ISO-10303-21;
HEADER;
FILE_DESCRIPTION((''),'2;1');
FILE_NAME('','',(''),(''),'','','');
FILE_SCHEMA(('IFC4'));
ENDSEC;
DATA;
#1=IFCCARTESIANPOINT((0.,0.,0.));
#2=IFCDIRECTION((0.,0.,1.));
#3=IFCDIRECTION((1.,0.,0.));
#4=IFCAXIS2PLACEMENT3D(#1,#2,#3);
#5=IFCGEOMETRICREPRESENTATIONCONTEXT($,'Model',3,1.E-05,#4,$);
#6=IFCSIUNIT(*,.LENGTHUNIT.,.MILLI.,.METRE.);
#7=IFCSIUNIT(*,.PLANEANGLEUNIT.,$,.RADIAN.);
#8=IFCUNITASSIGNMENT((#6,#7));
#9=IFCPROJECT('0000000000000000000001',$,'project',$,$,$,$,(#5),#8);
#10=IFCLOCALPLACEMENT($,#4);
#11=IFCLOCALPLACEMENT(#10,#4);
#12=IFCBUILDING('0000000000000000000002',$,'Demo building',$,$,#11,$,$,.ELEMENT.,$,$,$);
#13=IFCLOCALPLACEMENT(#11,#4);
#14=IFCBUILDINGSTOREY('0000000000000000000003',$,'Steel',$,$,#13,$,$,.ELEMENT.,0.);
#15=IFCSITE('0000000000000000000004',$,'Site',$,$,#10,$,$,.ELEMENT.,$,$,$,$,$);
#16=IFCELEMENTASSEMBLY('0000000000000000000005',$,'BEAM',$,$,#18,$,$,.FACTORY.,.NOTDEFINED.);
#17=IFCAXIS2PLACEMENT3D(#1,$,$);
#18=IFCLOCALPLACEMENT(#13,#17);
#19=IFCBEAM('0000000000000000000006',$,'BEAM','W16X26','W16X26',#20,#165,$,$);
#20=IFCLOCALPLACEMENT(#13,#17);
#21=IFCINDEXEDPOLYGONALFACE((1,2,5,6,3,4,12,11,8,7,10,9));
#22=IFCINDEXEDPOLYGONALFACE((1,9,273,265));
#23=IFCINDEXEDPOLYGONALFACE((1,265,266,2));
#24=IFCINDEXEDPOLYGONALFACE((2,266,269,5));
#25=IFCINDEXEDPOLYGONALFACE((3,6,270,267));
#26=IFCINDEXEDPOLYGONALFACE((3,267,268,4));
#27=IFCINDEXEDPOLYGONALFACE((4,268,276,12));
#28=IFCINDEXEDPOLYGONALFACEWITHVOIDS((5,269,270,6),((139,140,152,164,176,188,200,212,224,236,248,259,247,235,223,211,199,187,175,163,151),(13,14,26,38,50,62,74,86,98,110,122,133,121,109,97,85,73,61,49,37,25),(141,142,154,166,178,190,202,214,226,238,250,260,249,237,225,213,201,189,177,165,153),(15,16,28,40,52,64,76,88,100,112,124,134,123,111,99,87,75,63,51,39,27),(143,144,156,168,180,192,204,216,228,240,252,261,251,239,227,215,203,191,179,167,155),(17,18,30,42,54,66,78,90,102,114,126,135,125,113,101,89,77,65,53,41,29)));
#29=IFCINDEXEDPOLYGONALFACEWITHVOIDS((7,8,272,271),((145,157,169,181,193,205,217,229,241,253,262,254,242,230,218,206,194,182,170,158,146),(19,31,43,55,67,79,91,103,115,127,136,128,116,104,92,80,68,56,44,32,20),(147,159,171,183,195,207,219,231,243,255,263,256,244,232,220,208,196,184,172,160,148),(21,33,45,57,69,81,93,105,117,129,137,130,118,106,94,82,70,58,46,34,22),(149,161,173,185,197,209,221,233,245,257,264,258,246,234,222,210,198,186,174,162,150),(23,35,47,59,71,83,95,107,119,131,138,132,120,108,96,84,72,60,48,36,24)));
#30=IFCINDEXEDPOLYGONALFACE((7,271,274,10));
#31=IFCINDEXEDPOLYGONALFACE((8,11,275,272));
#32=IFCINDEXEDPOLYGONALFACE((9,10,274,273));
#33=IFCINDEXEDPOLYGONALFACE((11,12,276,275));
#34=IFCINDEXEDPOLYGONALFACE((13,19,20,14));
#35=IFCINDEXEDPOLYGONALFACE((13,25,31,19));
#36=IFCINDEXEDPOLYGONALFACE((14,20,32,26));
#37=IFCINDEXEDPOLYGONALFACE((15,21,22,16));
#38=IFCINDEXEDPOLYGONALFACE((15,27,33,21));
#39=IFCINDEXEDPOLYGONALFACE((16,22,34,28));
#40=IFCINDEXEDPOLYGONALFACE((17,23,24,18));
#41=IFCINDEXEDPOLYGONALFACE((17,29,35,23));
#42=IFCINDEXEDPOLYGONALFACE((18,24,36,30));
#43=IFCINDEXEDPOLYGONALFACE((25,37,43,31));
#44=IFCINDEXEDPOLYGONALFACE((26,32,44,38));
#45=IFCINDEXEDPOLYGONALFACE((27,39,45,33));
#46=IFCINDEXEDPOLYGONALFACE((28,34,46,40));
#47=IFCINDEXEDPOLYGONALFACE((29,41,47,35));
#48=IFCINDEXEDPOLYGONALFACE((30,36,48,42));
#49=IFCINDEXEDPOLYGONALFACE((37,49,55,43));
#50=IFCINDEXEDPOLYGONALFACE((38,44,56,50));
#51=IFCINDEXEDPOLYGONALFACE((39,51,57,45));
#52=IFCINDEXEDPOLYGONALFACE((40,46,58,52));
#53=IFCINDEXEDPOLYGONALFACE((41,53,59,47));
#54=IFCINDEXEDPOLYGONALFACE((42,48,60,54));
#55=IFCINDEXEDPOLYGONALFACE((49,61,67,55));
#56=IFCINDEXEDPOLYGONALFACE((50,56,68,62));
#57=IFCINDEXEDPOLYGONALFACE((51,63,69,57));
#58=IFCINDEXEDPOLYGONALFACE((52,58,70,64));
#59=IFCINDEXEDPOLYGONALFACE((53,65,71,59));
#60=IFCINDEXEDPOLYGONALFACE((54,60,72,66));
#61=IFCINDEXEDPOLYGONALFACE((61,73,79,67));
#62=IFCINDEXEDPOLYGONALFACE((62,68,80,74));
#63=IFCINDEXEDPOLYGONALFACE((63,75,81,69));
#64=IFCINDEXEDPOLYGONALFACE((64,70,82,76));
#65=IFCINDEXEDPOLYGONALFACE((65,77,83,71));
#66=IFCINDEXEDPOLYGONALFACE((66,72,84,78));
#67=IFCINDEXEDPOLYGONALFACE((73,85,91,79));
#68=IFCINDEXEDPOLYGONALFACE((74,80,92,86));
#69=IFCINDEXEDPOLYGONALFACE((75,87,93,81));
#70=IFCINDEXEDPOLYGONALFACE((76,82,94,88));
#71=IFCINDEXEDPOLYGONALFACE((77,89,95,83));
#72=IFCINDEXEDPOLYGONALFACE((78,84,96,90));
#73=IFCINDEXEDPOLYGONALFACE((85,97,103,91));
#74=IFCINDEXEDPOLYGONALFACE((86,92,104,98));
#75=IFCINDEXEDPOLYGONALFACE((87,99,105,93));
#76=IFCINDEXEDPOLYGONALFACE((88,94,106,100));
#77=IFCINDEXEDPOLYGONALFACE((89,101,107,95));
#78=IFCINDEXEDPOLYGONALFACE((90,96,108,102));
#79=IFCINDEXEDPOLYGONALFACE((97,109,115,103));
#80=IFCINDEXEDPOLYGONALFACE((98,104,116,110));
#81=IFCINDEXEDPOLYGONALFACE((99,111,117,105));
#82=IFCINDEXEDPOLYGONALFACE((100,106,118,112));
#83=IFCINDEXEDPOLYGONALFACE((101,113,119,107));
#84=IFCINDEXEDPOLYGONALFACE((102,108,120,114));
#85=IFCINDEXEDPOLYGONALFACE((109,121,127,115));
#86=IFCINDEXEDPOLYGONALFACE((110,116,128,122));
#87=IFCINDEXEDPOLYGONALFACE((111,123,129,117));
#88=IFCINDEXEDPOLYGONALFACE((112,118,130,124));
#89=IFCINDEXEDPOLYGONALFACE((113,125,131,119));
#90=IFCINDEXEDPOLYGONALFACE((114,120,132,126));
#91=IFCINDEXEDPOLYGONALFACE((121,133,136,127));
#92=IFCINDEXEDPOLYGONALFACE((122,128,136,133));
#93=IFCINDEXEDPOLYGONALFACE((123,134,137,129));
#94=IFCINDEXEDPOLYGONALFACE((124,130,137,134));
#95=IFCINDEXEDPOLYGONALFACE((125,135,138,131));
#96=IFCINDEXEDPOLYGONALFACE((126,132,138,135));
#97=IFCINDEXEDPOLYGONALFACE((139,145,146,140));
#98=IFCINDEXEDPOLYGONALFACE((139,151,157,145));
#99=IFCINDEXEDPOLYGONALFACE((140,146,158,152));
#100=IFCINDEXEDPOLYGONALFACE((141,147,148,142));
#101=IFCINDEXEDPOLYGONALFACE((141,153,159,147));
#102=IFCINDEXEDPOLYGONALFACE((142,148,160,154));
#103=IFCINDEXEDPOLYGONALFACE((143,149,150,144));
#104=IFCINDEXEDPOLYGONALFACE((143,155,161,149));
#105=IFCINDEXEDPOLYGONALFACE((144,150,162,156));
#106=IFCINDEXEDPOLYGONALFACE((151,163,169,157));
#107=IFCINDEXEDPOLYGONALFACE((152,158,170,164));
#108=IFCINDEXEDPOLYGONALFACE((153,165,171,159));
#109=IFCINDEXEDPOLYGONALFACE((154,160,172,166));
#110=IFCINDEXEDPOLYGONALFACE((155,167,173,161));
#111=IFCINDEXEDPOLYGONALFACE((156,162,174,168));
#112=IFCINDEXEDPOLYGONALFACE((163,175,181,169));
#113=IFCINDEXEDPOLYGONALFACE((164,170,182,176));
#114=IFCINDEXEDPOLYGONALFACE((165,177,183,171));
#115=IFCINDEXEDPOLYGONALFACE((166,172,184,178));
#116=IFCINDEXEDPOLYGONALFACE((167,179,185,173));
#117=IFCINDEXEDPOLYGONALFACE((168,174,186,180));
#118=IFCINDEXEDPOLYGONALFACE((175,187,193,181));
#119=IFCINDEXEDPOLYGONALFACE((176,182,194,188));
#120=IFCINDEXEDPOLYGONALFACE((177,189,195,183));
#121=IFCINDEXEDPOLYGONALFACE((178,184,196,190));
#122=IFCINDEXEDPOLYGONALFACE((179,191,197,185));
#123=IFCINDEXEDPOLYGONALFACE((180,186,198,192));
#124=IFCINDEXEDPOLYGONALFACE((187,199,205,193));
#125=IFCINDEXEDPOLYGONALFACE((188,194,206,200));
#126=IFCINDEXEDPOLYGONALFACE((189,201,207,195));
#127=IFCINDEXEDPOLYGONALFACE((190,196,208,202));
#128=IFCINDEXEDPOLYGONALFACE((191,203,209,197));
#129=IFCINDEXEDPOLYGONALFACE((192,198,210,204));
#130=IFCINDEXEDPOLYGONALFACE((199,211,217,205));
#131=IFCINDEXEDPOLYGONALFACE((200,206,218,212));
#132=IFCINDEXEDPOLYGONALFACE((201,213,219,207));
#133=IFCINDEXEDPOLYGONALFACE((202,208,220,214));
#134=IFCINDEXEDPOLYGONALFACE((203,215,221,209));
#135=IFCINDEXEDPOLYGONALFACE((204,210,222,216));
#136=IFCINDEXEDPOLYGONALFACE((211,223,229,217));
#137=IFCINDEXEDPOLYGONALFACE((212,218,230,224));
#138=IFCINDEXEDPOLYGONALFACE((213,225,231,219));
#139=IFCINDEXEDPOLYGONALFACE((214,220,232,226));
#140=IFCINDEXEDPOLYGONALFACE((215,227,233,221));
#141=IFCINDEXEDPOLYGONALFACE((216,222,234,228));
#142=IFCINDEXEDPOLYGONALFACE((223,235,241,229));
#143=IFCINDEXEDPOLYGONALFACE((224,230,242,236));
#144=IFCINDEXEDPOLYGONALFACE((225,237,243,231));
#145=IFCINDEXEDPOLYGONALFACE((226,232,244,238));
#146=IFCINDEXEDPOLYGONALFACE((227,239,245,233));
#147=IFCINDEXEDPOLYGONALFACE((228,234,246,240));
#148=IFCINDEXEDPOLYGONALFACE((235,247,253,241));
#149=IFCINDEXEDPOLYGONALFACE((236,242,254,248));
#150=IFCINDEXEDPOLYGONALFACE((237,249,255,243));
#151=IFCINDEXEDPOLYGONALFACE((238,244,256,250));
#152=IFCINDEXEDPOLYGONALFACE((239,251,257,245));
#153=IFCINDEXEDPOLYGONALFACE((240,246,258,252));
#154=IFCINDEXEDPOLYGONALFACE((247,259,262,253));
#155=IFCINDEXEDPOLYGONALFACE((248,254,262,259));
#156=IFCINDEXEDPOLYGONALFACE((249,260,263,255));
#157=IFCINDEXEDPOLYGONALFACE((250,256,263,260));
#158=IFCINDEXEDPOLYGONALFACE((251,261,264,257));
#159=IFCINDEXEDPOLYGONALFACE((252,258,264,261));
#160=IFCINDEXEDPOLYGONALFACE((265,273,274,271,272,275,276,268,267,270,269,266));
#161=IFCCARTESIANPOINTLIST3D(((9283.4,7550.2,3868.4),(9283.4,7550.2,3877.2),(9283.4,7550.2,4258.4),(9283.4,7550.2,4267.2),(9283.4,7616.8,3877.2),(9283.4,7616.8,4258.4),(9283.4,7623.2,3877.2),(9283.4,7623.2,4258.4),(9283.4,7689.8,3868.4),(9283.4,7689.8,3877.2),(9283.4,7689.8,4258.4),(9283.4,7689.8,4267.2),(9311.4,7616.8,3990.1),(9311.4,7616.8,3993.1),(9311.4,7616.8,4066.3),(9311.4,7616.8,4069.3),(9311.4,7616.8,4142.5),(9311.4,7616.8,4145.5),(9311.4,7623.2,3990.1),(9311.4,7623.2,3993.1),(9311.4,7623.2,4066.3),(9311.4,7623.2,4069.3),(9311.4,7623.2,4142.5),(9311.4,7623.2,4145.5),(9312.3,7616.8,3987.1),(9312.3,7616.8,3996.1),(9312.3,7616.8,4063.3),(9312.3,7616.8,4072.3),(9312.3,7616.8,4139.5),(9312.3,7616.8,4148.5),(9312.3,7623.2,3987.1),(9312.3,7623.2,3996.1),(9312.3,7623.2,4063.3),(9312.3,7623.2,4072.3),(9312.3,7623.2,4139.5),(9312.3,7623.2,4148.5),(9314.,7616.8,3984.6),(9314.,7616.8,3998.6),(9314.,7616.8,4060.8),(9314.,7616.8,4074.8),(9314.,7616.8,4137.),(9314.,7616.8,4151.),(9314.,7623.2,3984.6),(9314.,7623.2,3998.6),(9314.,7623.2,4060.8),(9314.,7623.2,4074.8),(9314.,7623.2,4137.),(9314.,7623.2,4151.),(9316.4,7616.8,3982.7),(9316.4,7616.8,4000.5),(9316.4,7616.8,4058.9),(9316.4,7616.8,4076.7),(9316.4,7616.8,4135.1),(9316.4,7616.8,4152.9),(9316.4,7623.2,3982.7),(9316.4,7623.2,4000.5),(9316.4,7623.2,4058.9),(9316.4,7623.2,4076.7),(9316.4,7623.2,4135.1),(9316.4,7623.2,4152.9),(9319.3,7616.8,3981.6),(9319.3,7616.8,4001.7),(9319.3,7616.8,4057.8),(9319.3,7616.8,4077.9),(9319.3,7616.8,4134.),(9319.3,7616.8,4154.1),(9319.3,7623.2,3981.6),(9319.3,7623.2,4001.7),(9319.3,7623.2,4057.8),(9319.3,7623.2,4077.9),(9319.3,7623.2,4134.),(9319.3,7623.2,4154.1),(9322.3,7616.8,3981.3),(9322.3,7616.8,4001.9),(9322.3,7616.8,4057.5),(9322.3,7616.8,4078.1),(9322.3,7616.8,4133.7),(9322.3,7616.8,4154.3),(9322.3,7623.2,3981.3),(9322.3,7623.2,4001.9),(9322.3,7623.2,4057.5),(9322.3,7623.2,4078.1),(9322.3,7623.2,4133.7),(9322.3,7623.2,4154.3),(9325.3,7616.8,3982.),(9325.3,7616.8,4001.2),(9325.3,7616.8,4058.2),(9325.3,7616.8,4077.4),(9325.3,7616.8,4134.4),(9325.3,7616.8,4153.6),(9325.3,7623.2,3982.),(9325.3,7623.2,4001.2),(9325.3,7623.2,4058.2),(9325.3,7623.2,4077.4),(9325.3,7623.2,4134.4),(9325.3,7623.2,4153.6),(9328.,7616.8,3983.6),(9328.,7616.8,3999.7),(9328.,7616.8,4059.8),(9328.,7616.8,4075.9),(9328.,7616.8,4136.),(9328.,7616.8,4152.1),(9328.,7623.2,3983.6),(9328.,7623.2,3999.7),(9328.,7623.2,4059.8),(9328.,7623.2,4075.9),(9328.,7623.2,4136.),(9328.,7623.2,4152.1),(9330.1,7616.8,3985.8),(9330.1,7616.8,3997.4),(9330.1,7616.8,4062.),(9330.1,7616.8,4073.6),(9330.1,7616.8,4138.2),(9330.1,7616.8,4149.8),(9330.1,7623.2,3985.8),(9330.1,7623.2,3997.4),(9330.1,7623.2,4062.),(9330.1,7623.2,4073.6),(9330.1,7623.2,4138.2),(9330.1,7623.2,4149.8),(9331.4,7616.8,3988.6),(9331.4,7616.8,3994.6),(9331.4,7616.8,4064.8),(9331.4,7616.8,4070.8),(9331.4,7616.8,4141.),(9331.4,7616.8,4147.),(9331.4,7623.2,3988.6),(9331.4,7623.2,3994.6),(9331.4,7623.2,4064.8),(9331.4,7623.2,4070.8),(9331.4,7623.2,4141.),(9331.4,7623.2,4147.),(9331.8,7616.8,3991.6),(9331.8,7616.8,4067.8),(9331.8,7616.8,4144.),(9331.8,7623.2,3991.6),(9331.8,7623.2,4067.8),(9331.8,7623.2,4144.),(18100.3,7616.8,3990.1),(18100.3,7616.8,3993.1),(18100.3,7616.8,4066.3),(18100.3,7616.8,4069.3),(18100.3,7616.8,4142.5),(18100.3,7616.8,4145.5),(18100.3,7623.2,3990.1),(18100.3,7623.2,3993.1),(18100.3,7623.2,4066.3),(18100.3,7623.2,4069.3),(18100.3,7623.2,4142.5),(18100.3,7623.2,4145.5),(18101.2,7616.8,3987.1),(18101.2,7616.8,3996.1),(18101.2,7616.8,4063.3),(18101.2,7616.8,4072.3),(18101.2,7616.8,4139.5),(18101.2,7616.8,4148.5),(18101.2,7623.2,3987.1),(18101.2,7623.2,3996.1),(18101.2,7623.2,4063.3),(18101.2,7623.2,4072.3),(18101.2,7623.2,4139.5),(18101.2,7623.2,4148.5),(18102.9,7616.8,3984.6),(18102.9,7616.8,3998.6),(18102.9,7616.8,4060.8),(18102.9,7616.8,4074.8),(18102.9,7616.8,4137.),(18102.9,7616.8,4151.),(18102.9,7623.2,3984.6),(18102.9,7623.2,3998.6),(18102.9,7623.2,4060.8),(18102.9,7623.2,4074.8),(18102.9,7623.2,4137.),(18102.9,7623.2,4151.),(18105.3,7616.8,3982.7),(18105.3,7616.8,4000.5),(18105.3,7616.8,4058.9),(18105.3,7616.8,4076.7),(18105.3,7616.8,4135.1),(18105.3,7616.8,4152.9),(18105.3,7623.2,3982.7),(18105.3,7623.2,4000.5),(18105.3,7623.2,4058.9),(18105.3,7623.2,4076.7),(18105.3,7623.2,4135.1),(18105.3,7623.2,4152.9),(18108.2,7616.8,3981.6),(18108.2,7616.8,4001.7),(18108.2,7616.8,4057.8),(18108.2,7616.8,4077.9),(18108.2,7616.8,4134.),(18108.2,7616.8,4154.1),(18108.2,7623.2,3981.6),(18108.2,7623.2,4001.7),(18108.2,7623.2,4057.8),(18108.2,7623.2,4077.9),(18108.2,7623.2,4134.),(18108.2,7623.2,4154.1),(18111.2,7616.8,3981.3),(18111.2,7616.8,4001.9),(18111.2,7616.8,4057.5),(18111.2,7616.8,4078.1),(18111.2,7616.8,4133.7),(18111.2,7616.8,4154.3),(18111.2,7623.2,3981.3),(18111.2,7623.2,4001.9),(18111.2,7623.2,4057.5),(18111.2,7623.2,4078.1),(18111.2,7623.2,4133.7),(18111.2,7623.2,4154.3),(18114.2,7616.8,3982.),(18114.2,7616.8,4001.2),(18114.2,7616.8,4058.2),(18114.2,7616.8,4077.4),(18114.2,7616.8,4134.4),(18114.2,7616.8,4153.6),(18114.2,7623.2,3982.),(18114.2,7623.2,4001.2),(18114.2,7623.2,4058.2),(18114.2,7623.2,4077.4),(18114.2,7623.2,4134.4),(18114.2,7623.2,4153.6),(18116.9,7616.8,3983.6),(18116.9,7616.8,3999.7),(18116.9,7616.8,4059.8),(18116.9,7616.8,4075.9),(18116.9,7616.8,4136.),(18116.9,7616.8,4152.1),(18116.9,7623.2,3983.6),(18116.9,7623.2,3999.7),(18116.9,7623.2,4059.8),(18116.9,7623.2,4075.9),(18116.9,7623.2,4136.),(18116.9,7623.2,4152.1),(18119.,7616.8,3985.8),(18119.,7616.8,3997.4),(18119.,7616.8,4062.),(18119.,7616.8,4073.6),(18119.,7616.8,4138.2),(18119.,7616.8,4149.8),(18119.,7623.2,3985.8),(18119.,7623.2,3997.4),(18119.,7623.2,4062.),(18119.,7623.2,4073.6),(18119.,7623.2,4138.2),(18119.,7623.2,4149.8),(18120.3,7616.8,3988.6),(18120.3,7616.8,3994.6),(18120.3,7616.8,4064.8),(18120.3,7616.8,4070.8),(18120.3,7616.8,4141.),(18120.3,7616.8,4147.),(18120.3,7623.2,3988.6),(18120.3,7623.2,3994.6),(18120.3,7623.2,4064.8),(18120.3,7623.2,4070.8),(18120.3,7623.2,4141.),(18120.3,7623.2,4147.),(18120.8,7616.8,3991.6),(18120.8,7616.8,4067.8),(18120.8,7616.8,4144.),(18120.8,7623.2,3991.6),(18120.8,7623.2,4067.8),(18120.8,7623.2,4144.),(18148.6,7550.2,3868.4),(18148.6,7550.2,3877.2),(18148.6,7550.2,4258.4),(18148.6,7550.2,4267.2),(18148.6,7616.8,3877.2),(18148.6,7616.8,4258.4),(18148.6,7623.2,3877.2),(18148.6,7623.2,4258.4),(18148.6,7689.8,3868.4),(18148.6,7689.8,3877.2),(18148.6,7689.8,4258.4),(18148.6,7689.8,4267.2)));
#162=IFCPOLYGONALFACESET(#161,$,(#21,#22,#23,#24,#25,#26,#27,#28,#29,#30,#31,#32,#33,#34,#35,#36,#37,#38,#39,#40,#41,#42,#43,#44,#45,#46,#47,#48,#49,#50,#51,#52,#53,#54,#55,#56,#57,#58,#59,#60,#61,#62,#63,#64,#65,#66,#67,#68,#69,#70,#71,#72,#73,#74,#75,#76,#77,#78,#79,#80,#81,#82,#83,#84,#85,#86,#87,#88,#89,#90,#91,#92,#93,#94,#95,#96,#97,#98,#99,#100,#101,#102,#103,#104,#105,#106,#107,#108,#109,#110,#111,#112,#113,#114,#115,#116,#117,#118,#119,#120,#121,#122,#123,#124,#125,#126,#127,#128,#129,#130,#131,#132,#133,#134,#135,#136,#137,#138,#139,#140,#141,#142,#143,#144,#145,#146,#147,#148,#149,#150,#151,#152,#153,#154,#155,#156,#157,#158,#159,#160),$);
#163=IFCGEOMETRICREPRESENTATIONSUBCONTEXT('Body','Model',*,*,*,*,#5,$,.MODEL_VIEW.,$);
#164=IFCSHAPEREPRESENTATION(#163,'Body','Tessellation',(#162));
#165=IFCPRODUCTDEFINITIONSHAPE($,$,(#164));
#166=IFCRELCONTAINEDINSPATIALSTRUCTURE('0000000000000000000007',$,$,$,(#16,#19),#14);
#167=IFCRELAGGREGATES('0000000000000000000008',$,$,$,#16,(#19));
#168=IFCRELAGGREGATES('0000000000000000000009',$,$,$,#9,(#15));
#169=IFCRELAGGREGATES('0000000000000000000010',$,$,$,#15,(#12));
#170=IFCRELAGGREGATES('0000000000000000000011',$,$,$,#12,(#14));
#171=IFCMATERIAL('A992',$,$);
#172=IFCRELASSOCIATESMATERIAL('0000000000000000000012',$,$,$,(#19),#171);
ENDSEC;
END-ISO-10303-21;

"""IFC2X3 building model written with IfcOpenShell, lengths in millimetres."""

from ifc_helpers import new_model, si_unit, frame, origin, origin_with_axes, origin_2d, place, context, subcontext, project, spatial, circle, i_section, extrude, boolean, material, element, aggregate, save


model = new_model("IFC2X3")

# Units and contexts
model_context = context("Model", 3, precision=1e-05, world=origin_with_axes())
body_context = subcontext(model_context, "Body", "Model", "MODEL_VIEW")
ifc_project = project(units=[si_unit("LENGTHUNIT", "METRE", prefix="MILLI"), si_unit("PLANEANGLEUNIT", "RADIAN")], contexts=[model_context])

# Site, building, storey
site_placement = place(None, origin_with_axes())
site = spatial("IfcSite", under=ifc_project, at=site_placement, Name="Site", CompositionType="ELEMENT")
building_placement = place(site_placement, origin_with_axes())
building = spatial("IfcBuilding", under=site, at=building_placement, Name="Demo building", CompositionType="ELEMENT")
placement = place(building_placement, origin_with_axes())
storey = spatial("IfcBuildingStorey", under=building, at=placement, Name="Steel", CompositionType="ELEMENT", Elevation=0.0)

# Shared definitions
ifc_material_1 = material(Name="A992")

# Element assembly, beam
assembly_1 = element("IfcElementAssembly", 1, at=placement, inside=storey, Name="BEAM", AssemblyPlace="FACTORY", PredefinedType="NOTDEFINED")
beam_1_placement = place(placement, frame((9283.4, 7620.0, 4067.8), z_axis=(1.0, 0.0, 0.0), x_axis=(0.0, 1.0, 0.0)))
beam_1 = element("IfcBeam", 2, at=beam_1_placement, inside=storey, material=ifc_material_1, Name="BEAM", Description="W16X26", ObjectType="W16X26", context=body_context, shape_type="CSG", body=[
    boolean("DIFFERENCE", boolean("DIFFERENCE", boolean("DIFFERENCE", boolean("DIFFERENCE", boolean("DIFFERENCE", boolean("DIFFERENCE", extrude(i_section(OverallWidth=139.7, OverallDepth=398.8, WebThickness=6.3, FlangeThickness=8.8, at=origin_2d()), origin(), (0.0, 0.0, 1.0), 8865.1), extrude(circle(Radius=10.3, at=origin_2d()), frame((-60.0, -76.2, 38.1), z_axis=(1.0, 0.0, 0.0), x_axis=(0.0, 0.0, 1.0)), (0.0, 0.0, 1.0), 120.0)), extrude(circle(Radius=10.3, at=origin_2d()), frame((-60.0, 0.0, 38.1), z_axis=(1.0, 0.0, 0.0), x_axis=(0.0, 0.0, 1.0)), (0.0, 0.0, 1.0), 120.0)), extrude(circle(Radius=10.3, at=origin_2d()), frame((-60.0, 76.2, 38.1), z_axis=(1.0, 0.0, 0.0), x_axis=(0.0, 0.0, 1.0)), (0.0, 0.0, 1.0), 120.0)), extrude(circle(Radius=10.3, at=origin_2d()), frame((-60.0, -76.2, 8827.0), z_axis=(1.0, 0.0, 0.0), x_axis=(0.0, 0.0, 1.0)), (0.0, 0.0, 1.0), 120.0)), extrude(circle(Radius=10.3, at=origin_2d()), frame((-60.0, 0.0, 8827.0), z_axis=(1.0, 0.0, 0.0), x_axis=(0.0, 0.0, 1.0)), (0.0, 0.0, 1.0), 120.0)), extrude(circle(Radius=10.3, at=origin_2d()), frame((-60.0, 76.2, 8827.0), z_axis=(1.0, 0.0, 0.0), x_axis=(0.0, 0.0, 1.0)), (0.0, 0.0, 1.0), 120.0)),
])

aggregate(assembly_1, [beam_1])

save(model, "model.ifc")
